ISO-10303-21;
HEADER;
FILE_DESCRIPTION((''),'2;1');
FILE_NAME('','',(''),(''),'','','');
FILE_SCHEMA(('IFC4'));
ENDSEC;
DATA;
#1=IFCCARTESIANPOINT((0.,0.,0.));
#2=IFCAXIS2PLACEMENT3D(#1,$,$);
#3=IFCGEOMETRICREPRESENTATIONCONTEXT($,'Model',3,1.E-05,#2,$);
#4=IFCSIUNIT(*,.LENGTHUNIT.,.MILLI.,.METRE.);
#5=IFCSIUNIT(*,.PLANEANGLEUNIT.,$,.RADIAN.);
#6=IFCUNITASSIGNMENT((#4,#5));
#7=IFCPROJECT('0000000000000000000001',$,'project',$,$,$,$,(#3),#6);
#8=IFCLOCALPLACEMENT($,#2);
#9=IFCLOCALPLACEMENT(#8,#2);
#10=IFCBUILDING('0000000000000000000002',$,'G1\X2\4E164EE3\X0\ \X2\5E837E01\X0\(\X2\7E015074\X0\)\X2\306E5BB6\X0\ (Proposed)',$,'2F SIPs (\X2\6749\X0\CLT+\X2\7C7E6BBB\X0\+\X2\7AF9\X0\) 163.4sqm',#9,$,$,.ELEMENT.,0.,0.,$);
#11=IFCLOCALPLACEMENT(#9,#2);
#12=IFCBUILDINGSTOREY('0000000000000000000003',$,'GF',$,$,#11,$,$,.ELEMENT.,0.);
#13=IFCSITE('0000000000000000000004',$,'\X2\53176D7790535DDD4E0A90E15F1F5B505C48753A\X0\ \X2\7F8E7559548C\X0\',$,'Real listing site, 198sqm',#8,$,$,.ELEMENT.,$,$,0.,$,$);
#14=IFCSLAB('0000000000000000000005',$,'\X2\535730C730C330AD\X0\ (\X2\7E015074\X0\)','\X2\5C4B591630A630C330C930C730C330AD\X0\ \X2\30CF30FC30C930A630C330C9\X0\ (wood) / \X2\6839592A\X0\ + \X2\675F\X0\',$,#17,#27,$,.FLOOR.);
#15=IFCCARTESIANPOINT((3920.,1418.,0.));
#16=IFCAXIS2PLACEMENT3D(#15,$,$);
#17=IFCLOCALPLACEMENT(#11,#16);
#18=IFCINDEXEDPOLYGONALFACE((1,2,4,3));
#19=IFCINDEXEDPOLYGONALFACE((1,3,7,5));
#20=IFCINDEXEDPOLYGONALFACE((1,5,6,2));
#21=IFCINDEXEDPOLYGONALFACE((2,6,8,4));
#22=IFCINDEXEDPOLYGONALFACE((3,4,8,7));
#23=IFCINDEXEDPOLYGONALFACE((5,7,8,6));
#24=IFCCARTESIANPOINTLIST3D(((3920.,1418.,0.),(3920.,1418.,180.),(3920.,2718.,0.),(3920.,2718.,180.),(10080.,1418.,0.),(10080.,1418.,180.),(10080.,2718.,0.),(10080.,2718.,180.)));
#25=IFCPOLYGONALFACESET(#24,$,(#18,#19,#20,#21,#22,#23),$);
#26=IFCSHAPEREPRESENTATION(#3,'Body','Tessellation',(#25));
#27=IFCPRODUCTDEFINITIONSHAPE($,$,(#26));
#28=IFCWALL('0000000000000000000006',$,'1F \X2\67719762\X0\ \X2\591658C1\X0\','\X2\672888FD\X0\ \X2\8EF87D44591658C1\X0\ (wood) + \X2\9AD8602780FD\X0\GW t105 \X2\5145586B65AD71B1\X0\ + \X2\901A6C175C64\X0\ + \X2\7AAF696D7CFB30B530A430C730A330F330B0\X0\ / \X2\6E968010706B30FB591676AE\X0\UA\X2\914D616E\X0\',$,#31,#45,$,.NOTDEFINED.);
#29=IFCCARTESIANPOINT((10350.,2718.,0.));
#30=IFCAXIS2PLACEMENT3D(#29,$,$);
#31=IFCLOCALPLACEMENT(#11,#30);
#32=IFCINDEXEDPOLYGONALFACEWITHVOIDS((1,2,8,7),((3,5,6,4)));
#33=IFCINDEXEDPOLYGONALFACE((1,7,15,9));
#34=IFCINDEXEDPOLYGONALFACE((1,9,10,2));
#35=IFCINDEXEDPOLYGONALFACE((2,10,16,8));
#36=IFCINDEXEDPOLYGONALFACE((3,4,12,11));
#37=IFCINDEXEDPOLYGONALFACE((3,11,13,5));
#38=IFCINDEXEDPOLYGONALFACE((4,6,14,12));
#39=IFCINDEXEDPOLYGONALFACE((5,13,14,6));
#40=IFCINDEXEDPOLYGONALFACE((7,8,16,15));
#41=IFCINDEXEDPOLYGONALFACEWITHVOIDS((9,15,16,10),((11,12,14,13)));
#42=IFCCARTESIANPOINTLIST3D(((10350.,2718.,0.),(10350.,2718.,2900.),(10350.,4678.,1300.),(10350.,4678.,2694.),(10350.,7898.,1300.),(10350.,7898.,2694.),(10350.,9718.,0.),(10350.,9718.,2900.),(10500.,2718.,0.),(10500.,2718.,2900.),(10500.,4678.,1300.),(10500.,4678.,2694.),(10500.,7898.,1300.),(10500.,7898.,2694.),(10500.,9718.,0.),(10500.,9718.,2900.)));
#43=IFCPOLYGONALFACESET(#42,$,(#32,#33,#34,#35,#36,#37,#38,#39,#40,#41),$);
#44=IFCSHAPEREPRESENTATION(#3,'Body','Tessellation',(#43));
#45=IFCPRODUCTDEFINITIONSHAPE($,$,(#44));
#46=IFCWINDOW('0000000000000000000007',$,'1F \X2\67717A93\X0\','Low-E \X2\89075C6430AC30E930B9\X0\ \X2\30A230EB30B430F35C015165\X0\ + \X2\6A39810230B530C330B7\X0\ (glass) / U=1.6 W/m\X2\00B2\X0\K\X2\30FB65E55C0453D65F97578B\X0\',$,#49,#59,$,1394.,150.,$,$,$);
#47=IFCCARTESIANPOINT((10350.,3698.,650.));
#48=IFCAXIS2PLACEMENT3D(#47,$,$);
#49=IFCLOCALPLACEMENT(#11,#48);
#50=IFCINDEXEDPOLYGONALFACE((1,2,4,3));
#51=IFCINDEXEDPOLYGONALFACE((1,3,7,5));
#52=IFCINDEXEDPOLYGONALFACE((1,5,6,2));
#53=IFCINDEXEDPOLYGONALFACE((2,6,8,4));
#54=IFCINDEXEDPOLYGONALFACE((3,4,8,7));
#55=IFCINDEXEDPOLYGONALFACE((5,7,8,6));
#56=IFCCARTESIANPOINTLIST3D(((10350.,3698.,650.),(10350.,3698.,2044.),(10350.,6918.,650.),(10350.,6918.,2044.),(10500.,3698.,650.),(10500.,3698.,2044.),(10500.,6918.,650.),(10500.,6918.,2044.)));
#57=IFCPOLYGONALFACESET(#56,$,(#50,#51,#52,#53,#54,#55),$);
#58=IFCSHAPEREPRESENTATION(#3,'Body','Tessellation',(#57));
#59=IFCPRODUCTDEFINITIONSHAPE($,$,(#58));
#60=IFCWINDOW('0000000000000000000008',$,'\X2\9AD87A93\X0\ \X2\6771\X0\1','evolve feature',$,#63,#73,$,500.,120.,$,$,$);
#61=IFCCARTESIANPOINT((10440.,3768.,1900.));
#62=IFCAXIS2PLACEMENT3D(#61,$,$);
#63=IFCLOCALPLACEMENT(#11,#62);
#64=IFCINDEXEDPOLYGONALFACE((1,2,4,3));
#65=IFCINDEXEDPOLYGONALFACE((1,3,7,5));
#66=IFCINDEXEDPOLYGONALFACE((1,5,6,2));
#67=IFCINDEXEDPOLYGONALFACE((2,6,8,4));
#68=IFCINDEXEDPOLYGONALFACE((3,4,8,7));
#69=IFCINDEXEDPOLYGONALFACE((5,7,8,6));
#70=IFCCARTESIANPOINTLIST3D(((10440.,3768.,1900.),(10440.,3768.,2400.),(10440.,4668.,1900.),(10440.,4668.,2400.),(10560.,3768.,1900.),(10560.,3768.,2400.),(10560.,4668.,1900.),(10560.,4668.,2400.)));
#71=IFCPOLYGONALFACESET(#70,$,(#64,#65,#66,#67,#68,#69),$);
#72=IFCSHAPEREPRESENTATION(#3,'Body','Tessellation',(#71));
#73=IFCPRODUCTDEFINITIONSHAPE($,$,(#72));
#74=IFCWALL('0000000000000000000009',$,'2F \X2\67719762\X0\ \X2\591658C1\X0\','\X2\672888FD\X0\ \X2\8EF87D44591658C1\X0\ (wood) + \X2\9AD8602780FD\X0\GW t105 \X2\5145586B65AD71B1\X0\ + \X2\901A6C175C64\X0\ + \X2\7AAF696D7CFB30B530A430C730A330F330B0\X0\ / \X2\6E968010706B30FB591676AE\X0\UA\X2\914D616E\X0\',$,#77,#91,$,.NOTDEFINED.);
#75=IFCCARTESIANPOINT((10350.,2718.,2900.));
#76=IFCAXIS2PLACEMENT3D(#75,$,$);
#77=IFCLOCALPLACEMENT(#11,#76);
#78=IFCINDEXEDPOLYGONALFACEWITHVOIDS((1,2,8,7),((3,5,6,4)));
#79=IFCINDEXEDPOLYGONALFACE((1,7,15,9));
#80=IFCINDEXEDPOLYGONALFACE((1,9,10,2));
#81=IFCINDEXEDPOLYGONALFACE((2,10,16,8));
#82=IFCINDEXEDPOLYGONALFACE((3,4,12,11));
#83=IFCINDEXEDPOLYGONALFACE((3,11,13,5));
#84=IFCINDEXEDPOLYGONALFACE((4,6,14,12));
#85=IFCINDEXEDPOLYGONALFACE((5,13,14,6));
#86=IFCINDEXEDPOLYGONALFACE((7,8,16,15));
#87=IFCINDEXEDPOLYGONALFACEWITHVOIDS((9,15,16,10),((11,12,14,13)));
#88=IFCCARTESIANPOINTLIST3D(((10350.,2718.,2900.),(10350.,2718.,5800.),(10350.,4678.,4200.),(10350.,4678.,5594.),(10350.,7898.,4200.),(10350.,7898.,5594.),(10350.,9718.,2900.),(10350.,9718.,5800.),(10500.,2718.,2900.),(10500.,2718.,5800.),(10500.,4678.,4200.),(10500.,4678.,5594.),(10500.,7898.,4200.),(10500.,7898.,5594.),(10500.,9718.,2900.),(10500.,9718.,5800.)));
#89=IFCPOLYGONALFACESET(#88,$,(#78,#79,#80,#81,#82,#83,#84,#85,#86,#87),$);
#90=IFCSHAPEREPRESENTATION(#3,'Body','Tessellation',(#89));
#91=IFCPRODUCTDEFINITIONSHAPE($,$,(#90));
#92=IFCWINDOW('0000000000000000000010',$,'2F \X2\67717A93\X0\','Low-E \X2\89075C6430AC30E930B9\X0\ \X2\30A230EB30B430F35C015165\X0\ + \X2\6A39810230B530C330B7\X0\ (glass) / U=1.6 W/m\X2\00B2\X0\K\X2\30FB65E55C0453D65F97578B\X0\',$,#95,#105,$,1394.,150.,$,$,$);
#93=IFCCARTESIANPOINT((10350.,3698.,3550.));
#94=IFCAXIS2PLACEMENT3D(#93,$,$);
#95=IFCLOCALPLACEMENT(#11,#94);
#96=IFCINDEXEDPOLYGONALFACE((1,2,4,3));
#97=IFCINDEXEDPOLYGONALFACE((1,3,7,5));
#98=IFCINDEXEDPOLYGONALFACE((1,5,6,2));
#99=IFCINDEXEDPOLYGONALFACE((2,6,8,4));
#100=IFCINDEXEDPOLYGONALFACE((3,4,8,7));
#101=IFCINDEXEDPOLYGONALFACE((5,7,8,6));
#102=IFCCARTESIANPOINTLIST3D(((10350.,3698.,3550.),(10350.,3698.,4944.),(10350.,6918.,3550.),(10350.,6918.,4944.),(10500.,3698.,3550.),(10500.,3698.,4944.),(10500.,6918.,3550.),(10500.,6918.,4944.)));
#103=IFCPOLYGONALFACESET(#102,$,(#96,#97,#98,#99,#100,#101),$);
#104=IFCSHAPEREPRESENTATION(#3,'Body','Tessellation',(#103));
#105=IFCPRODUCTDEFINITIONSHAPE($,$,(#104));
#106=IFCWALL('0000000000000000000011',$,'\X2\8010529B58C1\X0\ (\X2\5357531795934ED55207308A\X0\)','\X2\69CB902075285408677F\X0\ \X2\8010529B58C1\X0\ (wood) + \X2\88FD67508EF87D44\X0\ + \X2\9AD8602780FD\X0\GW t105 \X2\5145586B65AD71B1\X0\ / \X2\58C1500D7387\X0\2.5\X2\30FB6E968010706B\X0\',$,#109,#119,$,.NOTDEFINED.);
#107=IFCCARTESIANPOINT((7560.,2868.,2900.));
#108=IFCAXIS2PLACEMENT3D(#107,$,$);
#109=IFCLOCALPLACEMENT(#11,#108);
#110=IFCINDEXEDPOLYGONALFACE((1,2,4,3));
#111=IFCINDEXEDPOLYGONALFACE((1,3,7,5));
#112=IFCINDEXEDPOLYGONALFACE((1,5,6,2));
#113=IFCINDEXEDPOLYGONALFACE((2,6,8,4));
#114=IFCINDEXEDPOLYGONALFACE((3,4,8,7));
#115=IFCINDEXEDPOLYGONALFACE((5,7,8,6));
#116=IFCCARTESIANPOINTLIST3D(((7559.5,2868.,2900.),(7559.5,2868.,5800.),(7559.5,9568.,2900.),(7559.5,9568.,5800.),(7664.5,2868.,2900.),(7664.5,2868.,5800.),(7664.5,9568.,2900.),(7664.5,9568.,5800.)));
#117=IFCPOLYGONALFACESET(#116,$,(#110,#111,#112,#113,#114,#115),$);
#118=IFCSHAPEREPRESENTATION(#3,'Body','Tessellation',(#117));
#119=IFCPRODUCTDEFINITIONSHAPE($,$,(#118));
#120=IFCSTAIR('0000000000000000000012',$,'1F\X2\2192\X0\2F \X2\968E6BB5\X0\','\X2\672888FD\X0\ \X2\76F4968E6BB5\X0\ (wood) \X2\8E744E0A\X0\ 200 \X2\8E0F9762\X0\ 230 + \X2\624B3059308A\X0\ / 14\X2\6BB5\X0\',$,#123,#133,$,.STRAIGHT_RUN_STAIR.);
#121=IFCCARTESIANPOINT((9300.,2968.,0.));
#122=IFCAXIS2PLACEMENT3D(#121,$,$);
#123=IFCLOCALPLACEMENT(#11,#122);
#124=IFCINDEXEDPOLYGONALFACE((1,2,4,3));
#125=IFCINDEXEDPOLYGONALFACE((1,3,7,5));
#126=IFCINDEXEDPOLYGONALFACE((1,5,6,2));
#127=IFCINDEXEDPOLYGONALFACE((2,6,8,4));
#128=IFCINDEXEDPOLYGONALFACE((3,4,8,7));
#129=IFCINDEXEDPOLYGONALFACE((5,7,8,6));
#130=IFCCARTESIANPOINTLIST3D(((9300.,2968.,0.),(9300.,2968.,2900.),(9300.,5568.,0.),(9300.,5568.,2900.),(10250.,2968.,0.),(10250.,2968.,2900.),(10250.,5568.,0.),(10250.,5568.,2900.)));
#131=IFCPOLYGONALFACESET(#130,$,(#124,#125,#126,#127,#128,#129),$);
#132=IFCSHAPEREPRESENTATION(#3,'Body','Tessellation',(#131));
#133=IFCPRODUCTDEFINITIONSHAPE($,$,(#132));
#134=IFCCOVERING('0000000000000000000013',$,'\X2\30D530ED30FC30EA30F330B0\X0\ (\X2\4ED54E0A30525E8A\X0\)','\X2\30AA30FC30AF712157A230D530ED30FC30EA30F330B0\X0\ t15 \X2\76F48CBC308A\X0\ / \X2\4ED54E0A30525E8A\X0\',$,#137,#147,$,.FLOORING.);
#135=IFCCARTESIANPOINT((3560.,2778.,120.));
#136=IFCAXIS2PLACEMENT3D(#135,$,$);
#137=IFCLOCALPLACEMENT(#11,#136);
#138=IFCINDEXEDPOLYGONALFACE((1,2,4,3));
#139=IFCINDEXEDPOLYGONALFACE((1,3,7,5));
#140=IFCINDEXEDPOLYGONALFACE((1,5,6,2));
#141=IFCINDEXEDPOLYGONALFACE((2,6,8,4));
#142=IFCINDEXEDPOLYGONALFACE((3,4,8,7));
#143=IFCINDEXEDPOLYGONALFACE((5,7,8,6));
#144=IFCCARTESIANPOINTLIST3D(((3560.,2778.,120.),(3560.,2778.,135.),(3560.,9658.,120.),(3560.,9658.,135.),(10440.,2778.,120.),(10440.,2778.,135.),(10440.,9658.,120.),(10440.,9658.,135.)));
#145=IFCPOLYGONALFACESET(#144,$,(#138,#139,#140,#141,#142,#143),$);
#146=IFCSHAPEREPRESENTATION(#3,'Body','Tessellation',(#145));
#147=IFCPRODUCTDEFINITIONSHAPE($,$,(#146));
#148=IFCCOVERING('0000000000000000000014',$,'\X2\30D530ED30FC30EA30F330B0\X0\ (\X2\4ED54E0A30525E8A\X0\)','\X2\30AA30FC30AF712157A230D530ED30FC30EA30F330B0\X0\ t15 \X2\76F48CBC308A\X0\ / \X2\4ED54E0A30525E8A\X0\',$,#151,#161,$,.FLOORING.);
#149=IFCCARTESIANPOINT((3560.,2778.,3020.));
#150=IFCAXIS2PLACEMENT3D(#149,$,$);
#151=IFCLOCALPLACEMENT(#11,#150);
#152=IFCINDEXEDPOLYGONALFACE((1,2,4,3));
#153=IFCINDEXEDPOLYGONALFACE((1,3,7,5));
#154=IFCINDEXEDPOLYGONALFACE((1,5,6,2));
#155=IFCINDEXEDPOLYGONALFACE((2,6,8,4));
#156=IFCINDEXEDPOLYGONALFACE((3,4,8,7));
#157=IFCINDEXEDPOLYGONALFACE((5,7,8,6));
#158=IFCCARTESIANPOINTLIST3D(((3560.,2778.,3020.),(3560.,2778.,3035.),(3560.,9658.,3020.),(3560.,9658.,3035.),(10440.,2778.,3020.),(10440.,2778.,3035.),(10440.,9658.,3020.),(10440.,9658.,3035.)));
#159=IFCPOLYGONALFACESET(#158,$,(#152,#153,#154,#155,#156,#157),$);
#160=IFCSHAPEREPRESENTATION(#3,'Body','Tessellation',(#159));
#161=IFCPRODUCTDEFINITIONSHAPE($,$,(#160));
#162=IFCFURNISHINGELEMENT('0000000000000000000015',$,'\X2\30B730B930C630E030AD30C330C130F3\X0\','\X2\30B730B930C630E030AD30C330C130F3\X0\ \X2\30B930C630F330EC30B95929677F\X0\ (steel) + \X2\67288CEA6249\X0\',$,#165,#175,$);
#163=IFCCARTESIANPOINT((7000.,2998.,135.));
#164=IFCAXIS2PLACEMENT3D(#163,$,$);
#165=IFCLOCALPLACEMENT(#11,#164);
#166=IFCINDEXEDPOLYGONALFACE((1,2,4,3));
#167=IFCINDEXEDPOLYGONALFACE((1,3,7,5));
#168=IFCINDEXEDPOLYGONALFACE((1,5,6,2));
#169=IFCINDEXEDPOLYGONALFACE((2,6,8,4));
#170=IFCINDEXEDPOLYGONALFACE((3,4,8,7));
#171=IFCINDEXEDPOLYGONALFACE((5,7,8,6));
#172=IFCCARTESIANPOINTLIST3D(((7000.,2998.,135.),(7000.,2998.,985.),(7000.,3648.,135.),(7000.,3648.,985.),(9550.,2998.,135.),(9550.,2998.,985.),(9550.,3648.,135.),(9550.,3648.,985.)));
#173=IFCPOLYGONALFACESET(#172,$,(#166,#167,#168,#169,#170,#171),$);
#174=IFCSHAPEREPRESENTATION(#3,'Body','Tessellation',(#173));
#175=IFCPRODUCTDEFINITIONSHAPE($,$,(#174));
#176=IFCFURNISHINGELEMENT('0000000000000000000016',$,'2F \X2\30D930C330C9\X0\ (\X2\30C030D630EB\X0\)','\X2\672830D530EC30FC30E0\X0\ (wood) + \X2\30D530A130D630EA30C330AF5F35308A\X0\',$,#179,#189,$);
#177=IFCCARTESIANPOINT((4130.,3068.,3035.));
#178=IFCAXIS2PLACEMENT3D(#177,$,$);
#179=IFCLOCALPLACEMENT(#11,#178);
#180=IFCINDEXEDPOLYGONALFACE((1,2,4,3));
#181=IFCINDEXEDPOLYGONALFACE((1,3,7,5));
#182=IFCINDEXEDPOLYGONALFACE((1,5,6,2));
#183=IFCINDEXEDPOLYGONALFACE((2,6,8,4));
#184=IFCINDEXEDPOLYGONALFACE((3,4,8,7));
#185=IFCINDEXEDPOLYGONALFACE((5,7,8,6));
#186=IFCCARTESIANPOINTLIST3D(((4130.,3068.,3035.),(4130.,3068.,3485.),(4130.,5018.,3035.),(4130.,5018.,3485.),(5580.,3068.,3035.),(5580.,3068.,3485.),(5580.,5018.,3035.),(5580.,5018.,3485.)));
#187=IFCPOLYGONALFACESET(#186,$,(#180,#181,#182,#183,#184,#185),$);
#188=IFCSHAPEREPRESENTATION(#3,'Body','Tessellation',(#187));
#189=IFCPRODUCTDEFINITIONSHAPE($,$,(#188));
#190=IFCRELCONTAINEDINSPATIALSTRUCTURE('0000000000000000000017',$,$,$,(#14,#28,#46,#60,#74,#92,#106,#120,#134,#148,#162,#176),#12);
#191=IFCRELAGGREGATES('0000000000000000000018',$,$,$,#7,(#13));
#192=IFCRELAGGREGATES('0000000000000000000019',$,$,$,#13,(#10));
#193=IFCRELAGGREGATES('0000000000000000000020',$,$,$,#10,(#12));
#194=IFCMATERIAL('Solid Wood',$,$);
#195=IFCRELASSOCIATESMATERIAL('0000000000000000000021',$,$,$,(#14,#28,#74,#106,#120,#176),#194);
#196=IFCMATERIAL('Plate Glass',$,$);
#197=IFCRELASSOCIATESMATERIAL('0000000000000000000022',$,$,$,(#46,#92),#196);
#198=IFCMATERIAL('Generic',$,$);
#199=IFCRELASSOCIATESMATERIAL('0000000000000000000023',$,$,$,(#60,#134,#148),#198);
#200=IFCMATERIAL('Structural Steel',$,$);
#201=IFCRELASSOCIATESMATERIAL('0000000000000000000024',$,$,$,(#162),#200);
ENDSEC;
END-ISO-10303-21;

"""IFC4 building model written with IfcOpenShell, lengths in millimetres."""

from ifc_helpers import new_model, si_unit, frame, frame_2d, origin, place, context, project, spatial, rectangle, extrude, material, element, fill, save


model = new_model("IFC4")

# Units and contexts
model_context = context("Model", 3, precision=1e-05, world=origin())
ifc_project = project(units=[si_unit("LENGTHUNIT", "METRE", prefix="MILLI"), si_unit("PLANEANGLEUNIT", "RADIAN")], contexts=[model_context])

# Site, building, storey
site_placement = place(None, origin())
site = spatial("IfcSite", under=ifc_project, at=site_placement, Name="北海道川上郡弟子屈町 美留和", ObjectType="Real listing site, 198sqm", CompositionType="ELEMENT", RefElevation=0.0)
building_placement = place(site_placement, origin())
building = spatial("IfcBuilding", under=site, at=building_placement, Name="G1世代 広縁(縁側)の家 (Proposed)", ObjectType="2F SIPs (杉CLT+籾殻+竹) 163.4sqm", CompositionType="ELEMENT", ElevationOfRefHeight=0.0, ElevationOfTerrain=0.0)
storey_placement = place(building_placement, origin())
storey = spatial("IfcBuildingStorey", under=building, at=storey_placement, Name="GF", CompositionType="ELEMENT", Elevation=0.0)

# Slab
ifc_material_1 = material(Name="Solid Wood")
slab_placement = place(storey_placement, frame((3920.0, 1418.0, 0.0)))
element("IfcSlab", 1, at=slab_placement, inside=storey, material=ifc_material_1, Name="南デッキ (縁側)", Description="屋外ウッドデッキ ハードウッド (wood) / 根太 + 束", PredefinedType="FLOOR", context=model_context, shape_type="SweptSolid", body=[
    extrude(rectangle(XDim=6160.0, YDim=1300.0, at=frame_2d((3080.0, 650.0))), frame((3920.0, 1418.0, 0.0)), (0.0, 0.0, 1.0), 180.0),
])

# Wall, openings, windows
wall_1_placement = place(storey_placement, frame((10350.0, 2718.0, 0.0)))
wall_1 = element("IfcWall", 2, at=wall_1_placement, inside=storey, material=ifc_material_1, Name="1F 東面 外壁", Description="木製 軸組外壁 (wood) + 高性能GW t105 充填断熱 + 通気層 + 窯業系サイディング / 準耐火・外皮UA配慮", PredefinedType="NOTDEFINED", context=model_context, shape_type="SweptSolid", body=[
    extrude(rectangle(XDim=150.0, YDim=7000.0, at=frame_2d((75.0, 3500.0))), frame((10350.0, 2718.0, 0.0)), (0.0, 0.0, 1.0), 2900.0),
])
opening_1_placement = place(storey_placement, frame((10350.0, 3698.0, 650.0)))
opening_1 = element("IfcOpeningElement", 3, at=opening_1_placement, cuts=wall_1, PredefinedType="NOTDEFINED", context=model_context, shape_type="SweptSolid", body=[
    extrude(rectangle(XDim=150.0, YDim=3220.0, at=frame_2d((75.0, 1610.0))), frame((10350.0, 3698.0, 650.0)), (0.0, 0.0, 1.0), 1394.0),
])
opening_2_placement = place(storey_placement, frame((10440.0, 3768.0, 1900.0)))
opening_2 = element("IfcOpeningElement", 4, at=opening_2_placement, cuts=wall_1, PredefinedType="NOTDEFINED", context=model_context, shape_type="SweptSolid", body=[
    extrude(rectangle(XDim=120.0, YDim=900.0, at=frame_2d((60.0, 450.0))), frame((10440.0, 3768.0, 1900.0)), (0.0, 0.0, 1.0), 500.0),
])
ifc_material_2 = material(Name="Plate Glass")
window_1_placement = place(storey_placement, frame((10350.0, 3698.0, 650.0)))
window_1 = element("IfcWindow", 5, at=window_1_placement, inside=storey, material=ifc_material_2, Name="1F 東窓", Description="Low-E 複層ガラス アルゴン封入 + 樹脂サッシ (glass) / U=1.6 W/m²K・日射取得型", OverallHeight=1394.0, OverallWidth=150.0, context=model_context, shape_type="SweptSolid", body=[
    extrude(rectangle(XDim=150.0, YDim=3220.0, at=frame_2d((75.0, 1610.0))), frame((10350.0, 3698.0, 650.0)), (0.0, 0.0, 1.0), 1394.0),
])
fill(opening_1, window_1)
ifc_material_3 = material(Name="Generic")
window_2_placement = place(storey_placement, frame((10440.0, 3768.0, 1900.0)))
window_2 = element("IfcWindow", 6, at=window_2_placement, inside=storey, material=ifc_material_3, Name="高窓 東1", Description="evolve feature", OverallHeight=500.0, OverallWidth=120.0, context=model_context, shape_type="SweptSolid", body=[
    extrude(rectangle(XDim=120.0, YDim=900.0, at=frame_2d((60.0, 450.0))), frame((10440.0, 3768.0, 1900.0)), (0.0, 0.0, 1.0), 500.0),
])
fill(opening_2, window_2)

# Wall, opening, window
wall_2_placement = place(storey_placement, frame((10350.0, 2718.0, 2900.0)))
wall_2 = element("IfcWall", 7, at=wall_2_placement, inside=storey, material=ifc_material_1, Name="2F 東面 外壁", Description="木製 軸組外壁 (wood) + 高性能GW t105 充填断熱 + 通気層 + 窯業系サイディング / 準耐火・外皮UA配慮", PredefinedType="NOTDEFINED", context=model_context, shape_type="SweptSolid", body=[
    extrude(rectangle(XDim=150.0, YDim=7000.0, at=frame_2d((75.0, 3500.0))), frame((10350.0, 2718.0, 2900.0)), (0.0, 0.0, 1.0), 2900.0),
])
opening_3_placement = place(storey_placement, frame((10350.0, 3698.0, 3550.0)))
opening_3 = element("IfcOpeningElement", 8, at=opening_3_placement, cuts=wall_2, PredefinedType="NOTDEFINED", context=model_context, shape_type="SweptSolid", body=[
    extrude(rectangle(XDim=150.0, YDim=3220.0, at=frame_2d((75.0, 1610.0))), frame((10350.0, 3698.0, 3550.0)), (0.0, 0.0, 1.0), 1394.0),
])
window_3_placement = place(storey_placement, frame((10350.0, 3698.0, 3550.0)))
window_3 = element("IfcWindow", 9, at=window_3_placement, inside=storey, material=ifc_material_2, Name="2F 東窓", Description="Low-E 複層ガラス アルゴン封入 + 樹脂サッシ (glass) / U=1.6 W/m²K・日射取得型", OverallHeight=1394.0, OverallWidth=150.0, context=model_context, shape_type="SweptSolid", body=[
    extrude(rectangle(XDim=150.0, YDim=3220.0, at=frame_2d((75.0, 1610.0))), frame((10350.0, 3698.0, 3550.0)), (0.0, 0.0, 1.0), 1394.0),
])
fill(opening_3, window_3)

# Wall
wall_3_placement = place(storey_placement, frame((7560.0, 2868.0, 2900.0)))
element("IfcWall", 10, at=wall_3_placement, inside=storey, material=ifc_material_1, Name="耐力壁 (南北間仕切り)", Description="構造用合板 耐力壁 (wood) + 製材軸組 + 高性能GW t105 充填断熱 / 壁倍率2.5・準耐火", PredefinedType="NOTDEFINED", context=model_context, shape_type="SweptSolid", body=[
    extrude(rectangle(XDim=105.0, YDim=6700.0, at=frame_2d((52.0, 3350.0))), frame((7560.0, 2868.0, 2900.0)), (0.0, 0.0, 1.0), 2900.0),
])

# Stair
stair_placement = place(storey_placement, frame((9300.0, 2968.0, 0.0)))
element("IfcStair", 11, at=stair_placement, inside=storey, material=ifc_material_1, Name="1F→2F 階段", Description="木製 直階段 (wood) 蹴上 200 踏面 230 + 手すり / 14段", PredefinedType="STRAIGHT_RUN_STAIR", context=model_context, shape_type="SweptSolid", body=[
    extrude(rectangle(XDim=950.0, YDim=2600.0, at=frame_2d((475.0, 1300.0))), frame((9300.0, 2968.0, 0.0)), (0.0, 0.0, 1.0), 2900.0),
])

# Coverings
covering_1_placement = place(storey_placement, frame((3560.0, 2778.0, 120.0)))
element("IfcCovering", 12, at=covering_1_placement, inside=storey, material=ifc_material_3, Name="フローリング (仕上げ床)", Description="オーク無垢フローリング t15 直貼り / 仕上げ床", PredefinedType="FLOORING", context=model_context, shape_type="SweptSolid", body=[
    extrude(rectangle(XDim=6880.0, YDim=6880.0, at=frame_2d((3440.0, 3440.0))), frame((3560.0, 2778.0, 120.0)), (0.0, 0.0, 1.0), 15.0),
])
covering_2_placement = place(storey_placement, frame((3560.0, 2778.0, 3020.0)))
element("IfcCovering", 13, at=covering_2_placement, inside=storey, material=ifc_material_3, Name="フローリング (仕上げ床)", Description="オーク無垢フローリング t15 直貼り / 仕上げ床", PredefinedType="FLOORING", context=model_context, shape_type="SweptSolid", body=[
    extrude(rectangle(XDim=6880.0, YDim=6880.0, at=frame_2d((3440.0, 3440.0))), frame((3560.0, 2778.0, 3020.0)), (0.0, 0.0, 1.0), 15.0),
])

# Furnishing elements
ifc_material_4 = material(Name="Structural Steel")
furnishing_1_placement = place(storey_placement, frame((7000.0, 2998.0, 135.0)))
element("IfcFurnishingElement", 14, at=furnishing_1_placement, inside=storey, material=ifc_material_4, Name="システムキッチン", Description="システムキッチン ステンレス天板 (steel) + 木質扉", context=model_context, shape_type="SweptSolid", body=[
    extrude(rectangle(XDim=2550.0, YDim=650.0, at=frame_2d((1275.0, 325.0))), frame((7000.0, 2998.0, 135.0)), (0.0, 0.0, 1.0), 850.0),
])
furnishing_2_placement = place(storey_placement, frame((4130.0, 3068.0, 3035.0)))
element("IfcFurnishingElement", 15, at=furnishing_2_placement, inside=storey, material=ifc_material_1, Name="2F ベッド (ダブル)", Description="木フレーム (wood) + ファブリック張り", context=model_context, shape_type="SweptSolid", body=[
    extrude(rectangle(XDim=1450.0, YDim=1950.0, at=frame_2d((725.0, 975.0))), frame((4130.0, 3068.0, 3035.0)), (0.0, 0.0, 1.0), 450.0),
])

save(model, "model.ifc")
